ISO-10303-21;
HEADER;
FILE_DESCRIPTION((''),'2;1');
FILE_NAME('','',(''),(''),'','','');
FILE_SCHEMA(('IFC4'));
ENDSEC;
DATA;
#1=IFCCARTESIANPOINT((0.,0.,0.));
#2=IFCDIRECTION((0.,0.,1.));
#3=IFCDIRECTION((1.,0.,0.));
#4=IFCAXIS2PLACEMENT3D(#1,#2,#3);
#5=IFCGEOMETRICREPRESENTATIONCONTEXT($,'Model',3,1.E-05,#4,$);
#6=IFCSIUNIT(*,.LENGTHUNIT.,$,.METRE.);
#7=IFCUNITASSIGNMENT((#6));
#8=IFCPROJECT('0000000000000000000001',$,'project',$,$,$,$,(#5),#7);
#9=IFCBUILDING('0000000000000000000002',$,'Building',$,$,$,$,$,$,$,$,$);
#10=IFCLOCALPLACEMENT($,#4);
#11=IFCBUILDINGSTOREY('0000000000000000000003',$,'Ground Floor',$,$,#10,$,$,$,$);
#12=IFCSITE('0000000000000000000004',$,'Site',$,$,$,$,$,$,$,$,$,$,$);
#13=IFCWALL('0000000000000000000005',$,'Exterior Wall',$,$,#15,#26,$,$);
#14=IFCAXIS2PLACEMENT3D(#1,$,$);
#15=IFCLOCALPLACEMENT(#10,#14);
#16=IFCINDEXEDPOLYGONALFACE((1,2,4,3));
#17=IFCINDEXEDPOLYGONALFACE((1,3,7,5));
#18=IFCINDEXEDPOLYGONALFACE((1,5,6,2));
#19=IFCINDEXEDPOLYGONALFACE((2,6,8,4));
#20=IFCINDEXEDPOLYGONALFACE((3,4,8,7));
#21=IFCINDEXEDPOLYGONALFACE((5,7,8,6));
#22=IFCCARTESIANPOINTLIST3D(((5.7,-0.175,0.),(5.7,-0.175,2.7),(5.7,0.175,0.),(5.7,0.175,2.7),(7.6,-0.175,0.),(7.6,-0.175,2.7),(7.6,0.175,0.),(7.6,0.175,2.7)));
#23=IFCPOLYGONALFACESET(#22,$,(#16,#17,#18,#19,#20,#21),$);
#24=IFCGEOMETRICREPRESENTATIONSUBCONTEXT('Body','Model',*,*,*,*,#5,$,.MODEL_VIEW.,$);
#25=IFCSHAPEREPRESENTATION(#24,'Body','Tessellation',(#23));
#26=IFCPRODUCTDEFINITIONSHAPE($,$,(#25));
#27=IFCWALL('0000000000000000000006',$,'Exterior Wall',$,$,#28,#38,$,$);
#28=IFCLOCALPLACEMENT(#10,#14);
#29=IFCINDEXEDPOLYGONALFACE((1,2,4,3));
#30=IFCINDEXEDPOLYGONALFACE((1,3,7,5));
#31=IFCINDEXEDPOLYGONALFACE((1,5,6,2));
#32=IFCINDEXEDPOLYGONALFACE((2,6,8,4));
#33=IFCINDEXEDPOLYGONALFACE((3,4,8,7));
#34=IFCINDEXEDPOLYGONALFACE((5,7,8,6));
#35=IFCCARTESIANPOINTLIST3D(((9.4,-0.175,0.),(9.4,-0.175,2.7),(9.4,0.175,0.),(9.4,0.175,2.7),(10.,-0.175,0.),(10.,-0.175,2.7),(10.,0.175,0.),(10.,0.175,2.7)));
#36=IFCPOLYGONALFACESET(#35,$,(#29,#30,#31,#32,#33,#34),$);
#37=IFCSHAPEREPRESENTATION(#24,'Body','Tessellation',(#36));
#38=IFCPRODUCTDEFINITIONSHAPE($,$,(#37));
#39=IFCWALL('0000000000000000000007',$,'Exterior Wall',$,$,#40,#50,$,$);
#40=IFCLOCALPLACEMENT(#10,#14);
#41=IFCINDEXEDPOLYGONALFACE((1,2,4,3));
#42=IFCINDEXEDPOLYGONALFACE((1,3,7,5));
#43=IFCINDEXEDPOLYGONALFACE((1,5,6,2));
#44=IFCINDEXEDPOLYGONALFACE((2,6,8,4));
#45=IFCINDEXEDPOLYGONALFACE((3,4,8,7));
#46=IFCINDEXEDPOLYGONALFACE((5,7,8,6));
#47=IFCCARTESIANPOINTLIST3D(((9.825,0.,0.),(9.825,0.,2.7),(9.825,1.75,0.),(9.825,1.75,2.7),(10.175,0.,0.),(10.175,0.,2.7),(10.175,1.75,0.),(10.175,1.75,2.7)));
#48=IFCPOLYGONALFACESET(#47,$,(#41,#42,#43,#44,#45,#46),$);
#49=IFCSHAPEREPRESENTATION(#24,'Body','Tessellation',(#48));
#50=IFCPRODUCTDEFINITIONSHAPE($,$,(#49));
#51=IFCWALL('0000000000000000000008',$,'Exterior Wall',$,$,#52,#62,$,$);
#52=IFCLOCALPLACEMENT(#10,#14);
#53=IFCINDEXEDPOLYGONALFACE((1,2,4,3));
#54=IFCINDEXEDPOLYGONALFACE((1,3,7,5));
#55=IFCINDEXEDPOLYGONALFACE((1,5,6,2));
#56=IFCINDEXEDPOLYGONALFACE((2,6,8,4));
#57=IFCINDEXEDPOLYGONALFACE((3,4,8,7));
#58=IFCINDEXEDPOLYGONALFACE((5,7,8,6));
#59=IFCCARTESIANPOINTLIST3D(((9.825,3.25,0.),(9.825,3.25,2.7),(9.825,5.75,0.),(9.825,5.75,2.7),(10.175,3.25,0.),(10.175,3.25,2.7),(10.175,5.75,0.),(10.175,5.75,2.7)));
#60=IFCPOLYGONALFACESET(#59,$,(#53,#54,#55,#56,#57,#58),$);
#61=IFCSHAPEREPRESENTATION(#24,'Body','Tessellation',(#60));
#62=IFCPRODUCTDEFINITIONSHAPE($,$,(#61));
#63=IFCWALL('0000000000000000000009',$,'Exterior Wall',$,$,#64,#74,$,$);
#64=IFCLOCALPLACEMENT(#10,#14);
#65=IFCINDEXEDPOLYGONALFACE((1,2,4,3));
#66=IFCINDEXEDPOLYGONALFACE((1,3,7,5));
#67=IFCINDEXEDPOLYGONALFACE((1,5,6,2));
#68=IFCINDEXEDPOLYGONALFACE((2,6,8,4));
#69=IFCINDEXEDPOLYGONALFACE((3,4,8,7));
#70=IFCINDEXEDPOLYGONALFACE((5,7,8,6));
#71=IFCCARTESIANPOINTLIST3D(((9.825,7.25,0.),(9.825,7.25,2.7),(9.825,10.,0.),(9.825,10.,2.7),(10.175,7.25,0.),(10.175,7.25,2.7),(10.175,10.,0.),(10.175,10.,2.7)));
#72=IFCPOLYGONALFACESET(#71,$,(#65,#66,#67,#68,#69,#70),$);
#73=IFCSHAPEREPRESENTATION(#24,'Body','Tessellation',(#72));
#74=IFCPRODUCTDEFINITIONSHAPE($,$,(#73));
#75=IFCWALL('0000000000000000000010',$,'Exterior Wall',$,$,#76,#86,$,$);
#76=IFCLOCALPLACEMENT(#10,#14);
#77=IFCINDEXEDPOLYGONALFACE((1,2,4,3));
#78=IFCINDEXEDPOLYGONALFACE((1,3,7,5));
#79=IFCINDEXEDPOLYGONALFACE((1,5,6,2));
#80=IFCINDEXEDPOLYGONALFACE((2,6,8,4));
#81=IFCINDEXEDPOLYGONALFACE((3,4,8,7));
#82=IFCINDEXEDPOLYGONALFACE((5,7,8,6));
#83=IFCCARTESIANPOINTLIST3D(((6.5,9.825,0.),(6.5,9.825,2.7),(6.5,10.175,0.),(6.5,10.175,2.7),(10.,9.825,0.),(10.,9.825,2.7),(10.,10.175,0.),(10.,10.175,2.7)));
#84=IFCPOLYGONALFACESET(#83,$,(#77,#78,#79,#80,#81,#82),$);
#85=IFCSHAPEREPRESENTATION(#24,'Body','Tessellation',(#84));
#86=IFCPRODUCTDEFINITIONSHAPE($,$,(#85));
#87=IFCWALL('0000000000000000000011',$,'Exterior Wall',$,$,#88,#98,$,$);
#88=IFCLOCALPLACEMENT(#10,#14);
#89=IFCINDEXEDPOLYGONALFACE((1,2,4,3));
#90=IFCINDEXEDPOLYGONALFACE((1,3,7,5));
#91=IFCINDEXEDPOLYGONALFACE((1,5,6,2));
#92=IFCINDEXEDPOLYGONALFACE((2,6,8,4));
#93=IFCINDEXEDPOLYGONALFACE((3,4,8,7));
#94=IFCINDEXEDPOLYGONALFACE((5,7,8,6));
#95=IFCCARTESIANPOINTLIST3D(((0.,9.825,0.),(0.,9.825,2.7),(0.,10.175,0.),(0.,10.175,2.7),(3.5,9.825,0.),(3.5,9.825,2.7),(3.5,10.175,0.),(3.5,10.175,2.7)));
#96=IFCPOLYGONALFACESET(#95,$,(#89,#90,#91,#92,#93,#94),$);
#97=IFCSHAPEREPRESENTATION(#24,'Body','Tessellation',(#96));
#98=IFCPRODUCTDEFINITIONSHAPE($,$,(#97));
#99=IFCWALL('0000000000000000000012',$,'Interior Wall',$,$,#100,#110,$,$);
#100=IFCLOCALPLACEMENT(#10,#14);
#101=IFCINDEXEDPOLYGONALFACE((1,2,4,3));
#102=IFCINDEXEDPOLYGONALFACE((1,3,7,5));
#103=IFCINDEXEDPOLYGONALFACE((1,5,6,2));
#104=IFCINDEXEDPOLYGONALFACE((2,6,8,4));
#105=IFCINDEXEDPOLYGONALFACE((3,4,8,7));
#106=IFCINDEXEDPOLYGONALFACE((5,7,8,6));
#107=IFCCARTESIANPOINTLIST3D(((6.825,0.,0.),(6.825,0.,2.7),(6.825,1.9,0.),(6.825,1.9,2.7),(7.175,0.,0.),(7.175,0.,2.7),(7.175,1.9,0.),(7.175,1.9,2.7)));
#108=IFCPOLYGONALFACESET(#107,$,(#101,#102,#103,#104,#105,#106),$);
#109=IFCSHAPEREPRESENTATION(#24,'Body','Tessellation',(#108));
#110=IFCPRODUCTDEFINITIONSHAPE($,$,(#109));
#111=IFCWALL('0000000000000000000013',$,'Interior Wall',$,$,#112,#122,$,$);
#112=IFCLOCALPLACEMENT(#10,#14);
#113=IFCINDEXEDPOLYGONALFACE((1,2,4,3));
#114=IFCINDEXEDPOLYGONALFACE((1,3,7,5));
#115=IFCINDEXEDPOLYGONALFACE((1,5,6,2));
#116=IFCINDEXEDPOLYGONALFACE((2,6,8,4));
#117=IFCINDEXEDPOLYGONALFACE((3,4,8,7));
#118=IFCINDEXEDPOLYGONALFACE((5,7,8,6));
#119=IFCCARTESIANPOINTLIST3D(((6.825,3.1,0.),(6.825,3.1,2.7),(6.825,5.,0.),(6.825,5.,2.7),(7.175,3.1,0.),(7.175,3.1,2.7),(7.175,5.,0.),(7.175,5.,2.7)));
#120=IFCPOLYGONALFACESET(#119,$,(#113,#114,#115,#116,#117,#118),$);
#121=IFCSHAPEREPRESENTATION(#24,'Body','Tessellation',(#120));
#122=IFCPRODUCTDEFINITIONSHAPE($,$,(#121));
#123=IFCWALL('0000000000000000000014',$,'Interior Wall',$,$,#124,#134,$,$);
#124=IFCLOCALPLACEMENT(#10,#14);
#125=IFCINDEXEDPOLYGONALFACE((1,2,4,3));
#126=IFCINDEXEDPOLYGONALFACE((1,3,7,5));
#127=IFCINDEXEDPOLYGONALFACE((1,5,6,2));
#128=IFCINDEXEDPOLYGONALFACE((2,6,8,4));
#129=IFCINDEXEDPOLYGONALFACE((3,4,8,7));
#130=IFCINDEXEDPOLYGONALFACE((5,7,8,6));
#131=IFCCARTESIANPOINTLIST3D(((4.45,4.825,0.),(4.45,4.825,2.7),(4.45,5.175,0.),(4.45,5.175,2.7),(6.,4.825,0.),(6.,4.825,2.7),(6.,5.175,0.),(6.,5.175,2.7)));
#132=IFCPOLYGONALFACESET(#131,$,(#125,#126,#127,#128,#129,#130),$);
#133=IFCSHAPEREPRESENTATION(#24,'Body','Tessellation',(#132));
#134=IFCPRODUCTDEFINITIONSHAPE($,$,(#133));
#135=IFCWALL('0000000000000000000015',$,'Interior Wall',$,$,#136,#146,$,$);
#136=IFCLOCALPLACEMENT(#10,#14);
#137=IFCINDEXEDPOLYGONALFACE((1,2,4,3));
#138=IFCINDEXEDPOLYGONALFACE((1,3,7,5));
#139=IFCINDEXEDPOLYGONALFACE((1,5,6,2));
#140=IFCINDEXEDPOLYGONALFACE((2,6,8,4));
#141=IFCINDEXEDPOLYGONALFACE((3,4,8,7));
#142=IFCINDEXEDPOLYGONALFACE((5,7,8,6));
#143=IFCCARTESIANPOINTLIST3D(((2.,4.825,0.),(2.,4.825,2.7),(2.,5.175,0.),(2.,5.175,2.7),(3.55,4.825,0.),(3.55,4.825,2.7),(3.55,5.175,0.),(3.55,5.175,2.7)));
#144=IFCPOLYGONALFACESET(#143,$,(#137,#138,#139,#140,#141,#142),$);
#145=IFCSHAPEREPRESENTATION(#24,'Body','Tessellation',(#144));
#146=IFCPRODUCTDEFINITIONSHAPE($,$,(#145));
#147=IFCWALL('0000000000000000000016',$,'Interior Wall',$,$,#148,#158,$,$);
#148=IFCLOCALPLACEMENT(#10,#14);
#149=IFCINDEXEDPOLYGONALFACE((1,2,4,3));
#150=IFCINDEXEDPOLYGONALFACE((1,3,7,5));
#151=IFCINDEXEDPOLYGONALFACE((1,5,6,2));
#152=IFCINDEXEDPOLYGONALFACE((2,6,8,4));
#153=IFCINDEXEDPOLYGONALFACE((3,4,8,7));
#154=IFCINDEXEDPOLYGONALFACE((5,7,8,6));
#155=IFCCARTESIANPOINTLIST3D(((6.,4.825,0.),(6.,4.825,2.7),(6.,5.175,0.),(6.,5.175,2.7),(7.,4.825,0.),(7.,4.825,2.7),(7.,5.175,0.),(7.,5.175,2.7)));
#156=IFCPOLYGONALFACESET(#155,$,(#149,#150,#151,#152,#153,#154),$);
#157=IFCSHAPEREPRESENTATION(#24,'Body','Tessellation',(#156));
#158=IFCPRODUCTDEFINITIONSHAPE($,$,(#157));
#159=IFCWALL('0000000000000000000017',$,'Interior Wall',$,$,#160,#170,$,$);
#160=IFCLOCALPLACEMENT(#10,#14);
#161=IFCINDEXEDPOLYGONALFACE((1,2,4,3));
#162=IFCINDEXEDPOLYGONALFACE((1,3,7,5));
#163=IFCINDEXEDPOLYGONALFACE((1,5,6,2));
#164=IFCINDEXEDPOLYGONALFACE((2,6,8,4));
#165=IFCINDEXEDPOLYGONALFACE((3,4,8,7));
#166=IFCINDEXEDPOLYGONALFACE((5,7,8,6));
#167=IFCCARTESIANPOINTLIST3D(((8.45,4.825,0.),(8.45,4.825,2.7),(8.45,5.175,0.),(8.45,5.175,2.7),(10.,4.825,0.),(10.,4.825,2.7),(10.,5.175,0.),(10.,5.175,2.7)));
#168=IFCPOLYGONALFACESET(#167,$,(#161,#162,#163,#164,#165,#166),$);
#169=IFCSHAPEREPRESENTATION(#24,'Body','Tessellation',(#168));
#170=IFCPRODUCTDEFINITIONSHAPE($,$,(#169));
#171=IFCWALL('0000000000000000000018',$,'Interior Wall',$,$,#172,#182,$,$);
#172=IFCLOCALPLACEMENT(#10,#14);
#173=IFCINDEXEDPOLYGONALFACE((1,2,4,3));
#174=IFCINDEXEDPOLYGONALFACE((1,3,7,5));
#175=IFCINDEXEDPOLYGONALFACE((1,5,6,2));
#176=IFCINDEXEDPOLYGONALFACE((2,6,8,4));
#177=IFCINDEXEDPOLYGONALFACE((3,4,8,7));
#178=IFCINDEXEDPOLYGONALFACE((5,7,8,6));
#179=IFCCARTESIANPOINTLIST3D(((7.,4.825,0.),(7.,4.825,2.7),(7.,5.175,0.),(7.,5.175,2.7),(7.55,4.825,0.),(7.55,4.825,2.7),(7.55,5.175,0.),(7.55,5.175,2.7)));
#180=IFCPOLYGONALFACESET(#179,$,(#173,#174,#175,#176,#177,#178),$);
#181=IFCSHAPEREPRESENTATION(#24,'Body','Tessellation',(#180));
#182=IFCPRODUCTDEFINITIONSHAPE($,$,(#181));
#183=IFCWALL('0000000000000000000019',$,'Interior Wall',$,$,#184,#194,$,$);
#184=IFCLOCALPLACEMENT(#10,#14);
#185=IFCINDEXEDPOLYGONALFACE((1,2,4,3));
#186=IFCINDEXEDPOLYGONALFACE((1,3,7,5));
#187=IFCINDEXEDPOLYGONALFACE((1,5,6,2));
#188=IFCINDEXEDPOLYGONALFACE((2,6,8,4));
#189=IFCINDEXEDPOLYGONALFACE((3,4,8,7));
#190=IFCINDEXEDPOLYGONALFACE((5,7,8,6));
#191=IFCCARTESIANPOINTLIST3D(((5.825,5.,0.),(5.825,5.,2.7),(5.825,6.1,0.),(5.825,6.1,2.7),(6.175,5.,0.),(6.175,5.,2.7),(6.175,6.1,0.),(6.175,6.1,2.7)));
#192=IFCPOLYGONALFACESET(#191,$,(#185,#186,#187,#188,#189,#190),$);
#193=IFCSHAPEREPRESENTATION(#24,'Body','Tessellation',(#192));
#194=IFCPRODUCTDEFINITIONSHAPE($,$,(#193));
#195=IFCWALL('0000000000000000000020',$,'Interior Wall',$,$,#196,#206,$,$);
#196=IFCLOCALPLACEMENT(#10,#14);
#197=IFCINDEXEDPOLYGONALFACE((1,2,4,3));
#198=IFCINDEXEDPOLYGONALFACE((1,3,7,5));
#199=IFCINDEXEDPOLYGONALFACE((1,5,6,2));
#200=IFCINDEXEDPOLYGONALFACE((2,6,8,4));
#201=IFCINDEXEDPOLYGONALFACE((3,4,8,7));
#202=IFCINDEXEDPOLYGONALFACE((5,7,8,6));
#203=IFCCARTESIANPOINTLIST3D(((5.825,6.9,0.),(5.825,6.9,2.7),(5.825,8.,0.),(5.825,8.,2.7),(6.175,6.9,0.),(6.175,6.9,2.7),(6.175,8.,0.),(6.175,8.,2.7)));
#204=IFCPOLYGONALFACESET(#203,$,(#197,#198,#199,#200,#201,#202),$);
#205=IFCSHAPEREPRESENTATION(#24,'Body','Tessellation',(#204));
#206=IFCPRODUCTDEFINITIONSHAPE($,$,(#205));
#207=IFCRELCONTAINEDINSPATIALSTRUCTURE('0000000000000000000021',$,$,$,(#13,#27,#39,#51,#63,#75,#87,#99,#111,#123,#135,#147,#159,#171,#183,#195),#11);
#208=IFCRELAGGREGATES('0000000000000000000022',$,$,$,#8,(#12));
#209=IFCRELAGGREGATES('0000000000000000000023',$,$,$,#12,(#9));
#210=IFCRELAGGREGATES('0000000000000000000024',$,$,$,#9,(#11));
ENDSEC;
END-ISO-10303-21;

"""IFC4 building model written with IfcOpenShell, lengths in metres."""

from ifc_helpers import new_model, si_unit, frame, origin_with_axes, place, context, subcontext, project, spatial, indexed_curve, outline, extrude, element, save


model = new_model("IFC4")

# Units and contexts
model_context = context("Model", 3, precision=1e-05, world=origin_with_axes())
body_context = subcontext(model_context, "Body", "Model", "MODEL_VIEW")
ifc_project = project(units=[si_unit("LENGTHUNIT", "METRE")], contexts=[model_context])

# Site, building, storey
site = spatial("IfcSite", under=ifc_project, Name="Site")
building = spatial("IfcBuilding", under=site, Name="Building")
storey_placement = place(None, origin_with_axes())
storey = spatial("IfcBuildingStorey", under=building, at=storey_placement, Name="Ground Floor")

# Walls
wall_1_placement = place(storey_placement, frame((5.7, 0.0, 0.0), z_axis=(0.0, 0.0, 1.0), x_axis=(1.0, 0.0, 0.0)))
element("IfcWall", 1, at=wall_1_placement, inside=storey, Name="Exterior Wall", context=body_context, shape_type="SweptSolid", body=[
    extrude(outline(indexed_curve([(0.0, 0.0), (0.0, 0.35), (1.9, 0.35), (1.9, 0.0), (0.0, 0.0)], self_intersect=False)), frame((0.0, -0.175, 0.0), z_axis=(0.0, 0.0, 1.0), x_axis=(1.0, 0.0, 0.0)), (0.0, 0.0, 1.0), 2.7),
])
wall_2_placement = place(storey_placement, frame((9.4, 0.0, 0.0), z_axis=(0.0, 0.0, 1.0), x_axis=(1.0, 0.0, 0.0)))
element("IfcWall", 2, at=wall_2_placement, inside=storey, Name="Exterior Wall", context=body_context, shape_type="SweptSolid", body=[
    extrude(outline(indexed_curve([(0.0, 0.0), (0.0, 0.35), (0.6, 0.35), (0.6, 0.0), (0.0, 0.0)], self_intersect=False)), frame((0.0, -0.175, 0.0), z_axis=(0.0, 0.0, 1.0), x_axis=(1.0, 0.0, 0.0)), (0.0, 0.0, 1.0), 2.7),
])
wall_3_placement = place(storey_placement, frame((10.0, 0.0, 0.0), z_axis=(0.0, 0.0, 1.0), x_axis=(0.0, 1.0, 0.0)))
element("IfcWall", 3, at=wall_3_placement, inside=storey, Name="Exterior Wall", context=body_context, shape_type="SweptSolid", body=[
    extrude(outline(indexed_curve([(0.0, 0.0), (0.0, 0.35), (1.75, 0.35), (1.75, 0.0), (0.0, 0.0)], self_intersect=False)), frame((0.0, -0.175, 0.0), z_axis=(0.0, 0.0, 1.0), x_axis=(1.0, 0.0, 0.0)), (0.0, 0.0, 1.0), 2.7),
])
wall_4_placement = place(storey_placement, frame((10.0, 3.25, 0.0), z_axis=(0.0, 0.0, 1.0), x_axis=(0.0, 1.0, 0.0)))
element("IfcWall", 4, at=wall_4_placement, inside=storey, Name="Exterior Wall", context=body_context, shape_type="SweptSolid", body=[
    extrude(outline(indexed_curve([(0.0, 0.0), (0.0, 0.35), (2.5, 0.35), (2.5, 0.0), (0.0, 0.0)], self_intersect=False)), frame((0.0, -0.175, 0.0), z_axis=(0.0, 0.0, 1.0), x_axis=(1.0, 0.0, 0.0)), (0.0, 0.0, 1.0), 2.7),
])
wall_5_placement = place(storey_placement, frame((10.0, 7.25, 0.0), z_axis=(0.0, 0.0, 1.0), x_axis=(0.0, 1.0, 0.0)))
element("IfcWall", 5, at=wall_5_placement, inside=storey, Name="Exterior Wall", context=body_context, shape_type="SweptSolid", body=[
    extrude(outline(indexed_curve([(0.0, 0.0), (0.0, 0.35), (2.75, 0.35), (2.75, 0.0), (0.0, 0.0)], self_intersect=False)), frame((0.0, -0.175, 0.0), z_axis=(0.0, 0.0, 1.0), x_axis=(1.0, 0.0, 0.0)), (0.0, 0.0, 1.0), 2.7),
])
for number, where, z_axis, x_axis, name in (
    (6, (10.0, 10.0, 0.0), (0.0, 0.0, 1.0), (-1.0, 0.0, 0.0), "Exterior Wall"),
    (7, (3.5, 10.0, 0.0), (0.0, 0.0, 1.0), (-1.0, 0.0, 0.0), "Exterior Wall"),
):
    element("IfcWall", number, at=place(storey_placement, frame(where, z_axis=z_axis, x_axis=x_axis)), inside=storey, Name=name, context=body_context, shape_type="SweptSolid", body=[
        extrude(outline(indexed_curve([(0.0, 0.0), (0.0, 0.35), (3.5, 0.35), (3.5, 0.0), (0.0, 0.0)], self_intersect=False)), frame((0.0, -0.175, 0.0), z_axis=(0.0, 0.0, 1.0), x_axis=(1.0, 0.0, 0.0)), (0.0, 0.0, 1.0), 2.7),
    ])
for number, where, z_axis, x_axis, name in (
    (8, (7.0, 0.0, 0.0), (0.0, 0.0, 1.0), (0.0, 1.0, 0.0), "Interior Wall"),
    (9, (7.0, 3.1, 0.0), (0.0, 0.0, 1.0), (0.0, 1.0, 0.0), "Interior Wall"),
):
    element("IfcWall", number, at=place(storey_placement, frame(where, z_axis=z_axis, x_axis=x_axis)), inside=storey, Name=name, context=body_context, shape_type="SweptSolid", body=[
        extrude(outline(indexed_curve([(0.0, 0.0), (0.0, 0.35), (1.9, 0.35), (1.9, 0.0), (0.0, 0.0)], self_intersect=False)), frame((0.0, -0.175, 0.0), z_axis=(0.0, 0.0, 1.0), x_axis=(1.0, 0.0, 0.0)), (0.0, 0.0, 1.0), 2.7),
    ])
for number, where, z_axis, x_axis, name in (
    (10, (6.0, 5.0, 0.0), (0.0, 0.0, 1.0), (-1.0, 0.0, 0.0), "Interior Wall"),
    (11, (3.55, 5.0, 0.0), (0.0, 0.0, 1.0), (-1.0, 0.0, 0.0), "Interior Wall"),
):
    element("IfcWall", number, at=place(storey_placement, frame(where, z_axis=z_axis, x_axis=x_axis)), inside=storey, Name=name, context=body_context, shape_type="SweptSolid", body=[
        extrude(outline(indexed_curve([(0.0, 0.0), (0.0, 0.35), (1.55, 0.35), (1.55, 0.0), (0.0, 0.0)], self_intersect=False)), frame((0.0, -0.175, 0.0), z_axis=(0.0, 0.0, 1.0), x_axis=(1.0, 0.0, 0.0)), (0.0, 0.0, 1.0), 2.7),
    ])
wall_6_placement = place(storey_placement, frame((7.0, 5.0, 0.0), z_axis=(0.0, 0.0, 1.0), x_axis=(-1.0, 0.0, 0.0)))
element("IfcWall", 12, at=wall_6_placement, inside=storey, Name="Interior Wall", context=body_context, shape_type="SweptSolid", body=[
    extrude(outline(indexed_curve([(0.0, 0.0), (0.0, 0.35), (1.0, 0.35), (1.0, 0.0), (0.0, 0.0)], self_intersect=False)), frame((0.0, -0.175, 0.0), z_axis=(0.0, 0.0, 1.0), x_axis=(1.0, 0.0, 0.0)), (0.0, 0.0, 1.0), 2.7),
])
wall_7_placement = place(storey_placement, frame((10.0, 5.0, 0.0), z_axis=(0.0, 0.0, 1.0), x_axis=(-1.0, 0.0, 0.0)))
element("IfcWall", 13, at=wall_7_placement, inside=storey, Name="Interior Wall", context=body_context, shape_type="SweptSolid", body=[
    extrude(outline(indexed_curve([(0.0, 0.0), (0.0, 0.35), (1.55, 0.35), (1.55, 0.0), (0.0, 0.0)], self_intersect=False)), frame((0.0, -0.175, 0.0), z_axis=(0.0, 0.0, 1.0), x_axis=(1.0, 0.0, 0.0)), (0.0, 0.0, 1.0), 2.7),
])
wall_8_placement = place(storey_placement, frame((7.55, 5.0, 0.0), z_axis=(0.0, 0.0, 1.0), x_axis=(-1.0, 0.0, 0.0)))
element("IfcWall", 14, at=wall_8_placement, inside=storey, Name="Interior Wall", context=body_context, shape_type="SweptSolid", body=[
    extrude(outline(indexed_curve([(0.0, 0.0), (0.0, 0.35), (0.55, 0.35), (0.55, 0.0), (0.0, 0.0)], self_intersect=False)), frame((0.0, -0.175, 0.0), z_axis=(0.0, 0.0, 1.0), x_axis=(1.0, 0.0, 0.0)), (0.0, 0.0, 1.0), 2.7),
])
for number, where, z_axis, x_axis, name in (
    (15, (6.0, 5.0, 0.0), (0.0, 0.0, 1.0), (0.0, 1.0, 0.0), "Interior Wall"),
    (16, (6.0, 6.9, 0.0), (0.0, 0.0, 1.0), (0.0, 1.0, 0.0), "Interior Wall"),
):
    element("IfcWall", number, at=place(storey_placement, frame(where, z_axis=z_axis, x_axis=x_axis)), inside=storey, Name=name, context=body_context, shape_type="SweptSolid", body=[
        extrude(outline(indexed_curve([(0.0, 0.0), (0.0, 0.35), (1.1, 0.35), (1.1, 0.0), (0.0, 0.0)], self_intersect=False)), frame((0.0, -0.175, 0.0), z_axis=(0.0, 0.0, 1.0), x_axis=(1.0, 0.0, 0.0)), (0.0, 0.0, 1.0), 2.7),
    ])

save(model, "model.ifc")
